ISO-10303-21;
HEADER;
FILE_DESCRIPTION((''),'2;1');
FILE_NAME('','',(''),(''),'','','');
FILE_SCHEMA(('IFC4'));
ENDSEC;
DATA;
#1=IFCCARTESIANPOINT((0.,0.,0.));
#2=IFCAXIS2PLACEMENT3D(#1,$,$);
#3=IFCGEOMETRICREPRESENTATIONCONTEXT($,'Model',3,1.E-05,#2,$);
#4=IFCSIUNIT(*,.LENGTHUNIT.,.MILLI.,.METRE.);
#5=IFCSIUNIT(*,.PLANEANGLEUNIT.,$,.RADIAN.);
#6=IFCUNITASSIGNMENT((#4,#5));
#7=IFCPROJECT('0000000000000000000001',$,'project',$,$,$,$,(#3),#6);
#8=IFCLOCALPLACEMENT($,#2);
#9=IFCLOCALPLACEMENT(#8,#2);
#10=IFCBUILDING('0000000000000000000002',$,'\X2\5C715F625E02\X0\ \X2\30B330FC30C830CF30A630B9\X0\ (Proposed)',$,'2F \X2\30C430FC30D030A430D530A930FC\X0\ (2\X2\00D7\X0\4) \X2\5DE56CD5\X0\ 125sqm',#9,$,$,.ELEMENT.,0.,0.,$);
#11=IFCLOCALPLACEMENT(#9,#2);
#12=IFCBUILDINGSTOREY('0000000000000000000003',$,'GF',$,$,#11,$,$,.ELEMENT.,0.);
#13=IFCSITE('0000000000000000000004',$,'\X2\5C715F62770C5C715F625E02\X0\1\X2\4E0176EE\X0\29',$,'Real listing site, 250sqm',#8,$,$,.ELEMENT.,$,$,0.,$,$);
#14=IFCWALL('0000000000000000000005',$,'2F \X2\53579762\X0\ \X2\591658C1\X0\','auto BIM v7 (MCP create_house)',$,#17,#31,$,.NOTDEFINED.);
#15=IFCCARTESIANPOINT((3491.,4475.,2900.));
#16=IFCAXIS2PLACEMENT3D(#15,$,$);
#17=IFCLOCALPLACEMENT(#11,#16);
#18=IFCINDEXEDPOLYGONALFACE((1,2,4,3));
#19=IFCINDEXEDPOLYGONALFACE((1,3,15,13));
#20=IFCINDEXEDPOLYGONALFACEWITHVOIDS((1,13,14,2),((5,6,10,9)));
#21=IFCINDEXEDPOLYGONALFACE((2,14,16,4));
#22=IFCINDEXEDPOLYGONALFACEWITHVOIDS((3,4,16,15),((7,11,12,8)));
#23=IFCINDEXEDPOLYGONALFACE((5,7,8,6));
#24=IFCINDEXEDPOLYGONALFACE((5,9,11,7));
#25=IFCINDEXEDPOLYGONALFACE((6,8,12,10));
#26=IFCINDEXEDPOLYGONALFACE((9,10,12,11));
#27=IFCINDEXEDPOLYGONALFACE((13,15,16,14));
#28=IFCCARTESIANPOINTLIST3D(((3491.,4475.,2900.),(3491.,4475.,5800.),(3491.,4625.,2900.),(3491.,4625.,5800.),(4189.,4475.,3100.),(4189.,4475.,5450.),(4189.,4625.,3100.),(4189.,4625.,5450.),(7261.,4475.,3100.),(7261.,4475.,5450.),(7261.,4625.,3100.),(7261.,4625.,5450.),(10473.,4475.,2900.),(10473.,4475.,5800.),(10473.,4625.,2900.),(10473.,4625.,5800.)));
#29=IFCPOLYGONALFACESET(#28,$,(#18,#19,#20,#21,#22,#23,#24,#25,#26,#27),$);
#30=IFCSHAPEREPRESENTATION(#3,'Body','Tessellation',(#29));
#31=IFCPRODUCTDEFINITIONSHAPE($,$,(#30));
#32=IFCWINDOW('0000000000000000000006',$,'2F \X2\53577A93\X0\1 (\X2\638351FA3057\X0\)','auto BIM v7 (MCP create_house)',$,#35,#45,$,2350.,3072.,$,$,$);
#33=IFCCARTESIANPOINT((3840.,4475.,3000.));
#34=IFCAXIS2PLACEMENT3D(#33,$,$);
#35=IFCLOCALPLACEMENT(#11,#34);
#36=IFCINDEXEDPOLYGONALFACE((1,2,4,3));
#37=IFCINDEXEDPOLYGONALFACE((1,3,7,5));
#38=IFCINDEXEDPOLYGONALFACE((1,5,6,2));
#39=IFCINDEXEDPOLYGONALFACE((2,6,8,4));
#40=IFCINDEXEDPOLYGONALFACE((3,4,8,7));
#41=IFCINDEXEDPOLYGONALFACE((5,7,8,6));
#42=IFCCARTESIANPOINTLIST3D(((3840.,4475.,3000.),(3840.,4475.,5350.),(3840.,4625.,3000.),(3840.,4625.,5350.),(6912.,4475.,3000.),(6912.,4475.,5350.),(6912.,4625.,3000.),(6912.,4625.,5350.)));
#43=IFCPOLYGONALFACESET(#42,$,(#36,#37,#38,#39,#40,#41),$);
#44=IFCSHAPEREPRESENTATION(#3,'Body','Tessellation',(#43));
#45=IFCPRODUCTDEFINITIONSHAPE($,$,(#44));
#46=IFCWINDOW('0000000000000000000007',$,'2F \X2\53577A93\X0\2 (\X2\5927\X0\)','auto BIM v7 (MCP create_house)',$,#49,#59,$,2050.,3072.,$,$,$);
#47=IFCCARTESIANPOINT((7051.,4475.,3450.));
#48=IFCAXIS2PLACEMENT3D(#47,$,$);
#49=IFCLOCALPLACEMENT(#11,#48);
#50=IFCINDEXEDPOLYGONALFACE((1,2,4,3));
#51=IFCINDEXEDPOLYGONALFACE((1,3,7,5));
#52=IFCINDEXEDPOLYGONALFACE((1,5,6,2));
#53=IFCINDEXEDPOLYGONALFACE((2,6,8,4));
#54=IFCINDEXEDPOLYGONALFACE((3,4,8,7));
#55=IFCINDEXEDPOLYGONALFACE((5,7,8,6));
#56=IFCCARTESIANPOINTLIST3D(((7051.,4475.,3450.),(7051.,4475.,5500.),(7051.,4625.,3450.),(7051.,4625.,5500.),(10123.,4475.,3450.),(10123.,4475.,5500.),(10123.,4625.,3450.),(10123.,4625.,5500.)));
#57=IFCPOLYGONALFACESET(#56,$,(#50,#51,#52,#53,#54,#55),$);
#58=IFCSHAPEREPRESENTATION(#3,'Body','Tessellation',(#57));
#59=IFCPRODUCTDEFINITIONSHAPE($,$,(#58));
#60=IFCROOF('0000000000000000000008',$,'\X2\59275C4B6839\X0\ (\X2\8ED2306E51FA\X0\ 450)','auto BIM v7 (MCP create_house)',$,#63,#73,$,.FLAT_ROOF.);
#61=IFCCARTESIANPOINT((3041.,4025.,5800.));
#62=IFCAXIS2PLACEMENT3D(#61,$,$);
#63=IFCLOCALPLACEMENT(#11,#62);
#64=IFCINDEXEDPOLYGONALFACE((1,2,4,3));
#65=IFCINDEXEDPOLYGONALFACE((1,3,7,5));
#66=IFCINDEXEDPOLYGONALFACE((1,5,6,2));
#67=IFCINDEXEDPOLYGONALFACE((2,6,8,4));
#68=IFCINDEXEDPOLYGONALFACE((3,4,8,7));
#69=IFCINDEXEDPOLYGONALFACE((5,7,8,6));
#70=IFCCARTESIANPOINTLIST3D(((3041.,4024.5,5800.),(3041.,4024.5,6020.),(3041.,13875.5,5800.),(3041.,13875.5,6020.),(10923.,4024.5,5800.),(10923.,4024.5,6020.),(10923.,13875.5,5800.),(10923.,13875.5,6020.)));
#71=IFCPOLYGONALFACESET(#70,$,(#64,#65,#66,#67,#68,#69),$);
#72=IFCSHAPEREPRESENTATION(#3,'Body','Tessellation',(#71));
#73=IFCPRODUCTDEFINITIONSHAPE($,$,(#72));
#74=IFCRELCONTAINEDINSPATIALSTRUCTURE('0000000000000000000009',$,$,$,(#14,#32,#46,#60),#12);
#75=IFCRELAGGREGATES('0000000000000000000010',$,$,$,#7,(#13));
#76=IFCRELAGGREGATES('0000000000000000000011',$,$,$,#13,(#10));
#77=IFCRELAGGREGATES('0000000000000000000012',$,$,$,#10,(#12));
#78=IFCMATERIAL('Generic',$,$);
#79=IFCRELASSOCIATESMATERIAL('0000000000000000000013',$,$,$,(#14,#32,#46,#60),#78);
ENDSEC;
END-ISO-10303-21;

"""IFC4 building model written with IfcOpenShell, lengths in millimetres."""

from ifc_helpers import new_model, si_unit, frame, frame_2d, origin, place, context, project, spatial, rectangle, extrude, material, element, fill, save


model = new_model("IFC4")

# Units and contexts
model_context = context("Model", 3, precision=1e-05, world=origin())
ifc_project = project(units=[si_unit("LENGTHUNIT", "METRE", prefix="MILLI"), si_unit("PLANEANGLEUNIT", "RADIAN")], contexts=[model_context])

# Site, building, storey
site_placement = place(None, origin())
site = spatial("IfcSite", under=ifc_project, at=site_placement, Name="山形県山形市1丁目29", ObjectType="Real listing site, 250sqm", CompositionType="ELEMENT", RefElevation=0.0)
building_placement = place(site_placement, origin())
building = spatial("IfcBuilding", under=site, at=building_placement, Name="山形市 コートハウス (Proposed)", ObjectType="2F ツーバイフォー (2×4) 工法 125sqm", CompositionType="ELEMENT", ElevationOfRefHeight=0.0, ElevationOfTerrain=0.0)
storey_placement = place(building_placement, origin())
storey = spatial("IfcBuildingStorey", under=building, at=storey_placement, Name="GF", CompositionType="ELEMENT", Elevation=0.0)

# Shared definitions
ifc_material = material(Name="Generic")

# Wall, openings, windows
wall_1_placement = place(storey_placement, frame((3491.0, 4475.0, 2900.0)))
wall_1 = element("IfcWall", 1, at=wall_1_placement, inside=storey, material=ifc_material, Name="2F 南面 外壁", Description="auto BIM v7 (MCP create_house)", PredefinedType="NOTDEFINED", context=model_context, shape_type="SweptSolid", body=[
    extrude(rectangle(XDim=6982.0, YDim=150.0, at=frame_2d((3491.0, 75.0))), frame((3491.0, 4475.0, 2900.0)), (0.0, 0.0, 1.0), 2900.0),
])
opening_1_placement = place(storey_placement, frame((3840.0, 4475.0, 3000.0)))
opening_1 = element("IfcOpeningElement", 2, at=opening_1_placement, cuts=wall_1, PredefinedType="NOTDEFINED", context=model_context, shape_type="SweptSolid", body=[
    extrude(rectangle(XDim=3072.0, YDim=150.0, at=frame_2d((1536.0, 75.0))), frame((3840.0, 4475.0, 3000.0)), (0.0, 0.0, 1.0), 2350.0),
])
opening_2_placement = place(storey_placement, frame((7051.0, 4475.0, 3450.0)))
opening_2 = element("IfcOpeningElement", 3, at=opening_2_placement, cuts=wall_1, PredefinedType="NOTDEFINED", context=model_context, shape_type="SweptSolid", body=[
    extrude(rectangle(XDim=3072.0, YDim=150.0, at=frame_2d((1536.0, 75.0))), frame((7051.0, 4475.0, 3450.0)), (0.0, 0.0, 1.0), 2050.0),
])
window_1_placement = place(storey_placement, frame((3840.0, 4475.0, 3000.0)))
window_1 = element("IfcWindow", 4, at=window_1_placement, inside=storey, material=ifc_material, Name="2F 南窓1 (掃出し)", Description="auto BIM v7 (MCP create_house)", OverallHeight=2350.0, OverallWidth=3072.0, context=model_context, shape_type="SweptSolid", body=[
    extrude(rectangle(XDim=3072.0, YDim=150.0, at=frame_2d((1536.0, 75.0))), frame((3840.0, 4475.0, 3000.0)), (0.0, 0.0, 1.0), 2350.0),
])
fill(opening_1, window_1)
window_2_placement = place(storey_placement, frame((7051.0, 4475.0, 3450.0)))
window_2 = element("IfcWindow", 5, at=window_2_placement, inside=storey, material=ifc_material, Name="2F 南窓2 (大)", Description="auto BIM v7 (MCP create_house)", OverallHeight=2050.0, OverallWidth=3072.0, context=model_context, shape_type="SweptSolid", body=[
    extrude(rectangle(XDim=3072.0, YDim=150.0, at=frame_2d((1536.0, 75.0))), frame((7051.0, 4475.0, 3450.0)), (0.0, 0.0, 1.0), 2050.0),
])
fill(opening_2, window_2)

# Roof
roof_placement = place(storey_placement, frame((3041.0, 4025.0, 5800.0)))
element("IfcRoof", 6, at=roof_placement, inside=storey, material=ifc_material, Name="大屋根 (軒の出 450)", Description="auto BIM v7 (MCP create_house)", PredefinedType="FLAT_ROOF", context=model_context, shape_type="SweptSolid", body=[
    extrude(rectangle(XDim=7882.0, YDim=9851.0, at=frame_2d((3941.0, 4925.0))), frame((3041.0, 4025.0, 5800.0)), (0.0, 0.0, 1.0), 220.0),
])

save(model, "model.ifc")
